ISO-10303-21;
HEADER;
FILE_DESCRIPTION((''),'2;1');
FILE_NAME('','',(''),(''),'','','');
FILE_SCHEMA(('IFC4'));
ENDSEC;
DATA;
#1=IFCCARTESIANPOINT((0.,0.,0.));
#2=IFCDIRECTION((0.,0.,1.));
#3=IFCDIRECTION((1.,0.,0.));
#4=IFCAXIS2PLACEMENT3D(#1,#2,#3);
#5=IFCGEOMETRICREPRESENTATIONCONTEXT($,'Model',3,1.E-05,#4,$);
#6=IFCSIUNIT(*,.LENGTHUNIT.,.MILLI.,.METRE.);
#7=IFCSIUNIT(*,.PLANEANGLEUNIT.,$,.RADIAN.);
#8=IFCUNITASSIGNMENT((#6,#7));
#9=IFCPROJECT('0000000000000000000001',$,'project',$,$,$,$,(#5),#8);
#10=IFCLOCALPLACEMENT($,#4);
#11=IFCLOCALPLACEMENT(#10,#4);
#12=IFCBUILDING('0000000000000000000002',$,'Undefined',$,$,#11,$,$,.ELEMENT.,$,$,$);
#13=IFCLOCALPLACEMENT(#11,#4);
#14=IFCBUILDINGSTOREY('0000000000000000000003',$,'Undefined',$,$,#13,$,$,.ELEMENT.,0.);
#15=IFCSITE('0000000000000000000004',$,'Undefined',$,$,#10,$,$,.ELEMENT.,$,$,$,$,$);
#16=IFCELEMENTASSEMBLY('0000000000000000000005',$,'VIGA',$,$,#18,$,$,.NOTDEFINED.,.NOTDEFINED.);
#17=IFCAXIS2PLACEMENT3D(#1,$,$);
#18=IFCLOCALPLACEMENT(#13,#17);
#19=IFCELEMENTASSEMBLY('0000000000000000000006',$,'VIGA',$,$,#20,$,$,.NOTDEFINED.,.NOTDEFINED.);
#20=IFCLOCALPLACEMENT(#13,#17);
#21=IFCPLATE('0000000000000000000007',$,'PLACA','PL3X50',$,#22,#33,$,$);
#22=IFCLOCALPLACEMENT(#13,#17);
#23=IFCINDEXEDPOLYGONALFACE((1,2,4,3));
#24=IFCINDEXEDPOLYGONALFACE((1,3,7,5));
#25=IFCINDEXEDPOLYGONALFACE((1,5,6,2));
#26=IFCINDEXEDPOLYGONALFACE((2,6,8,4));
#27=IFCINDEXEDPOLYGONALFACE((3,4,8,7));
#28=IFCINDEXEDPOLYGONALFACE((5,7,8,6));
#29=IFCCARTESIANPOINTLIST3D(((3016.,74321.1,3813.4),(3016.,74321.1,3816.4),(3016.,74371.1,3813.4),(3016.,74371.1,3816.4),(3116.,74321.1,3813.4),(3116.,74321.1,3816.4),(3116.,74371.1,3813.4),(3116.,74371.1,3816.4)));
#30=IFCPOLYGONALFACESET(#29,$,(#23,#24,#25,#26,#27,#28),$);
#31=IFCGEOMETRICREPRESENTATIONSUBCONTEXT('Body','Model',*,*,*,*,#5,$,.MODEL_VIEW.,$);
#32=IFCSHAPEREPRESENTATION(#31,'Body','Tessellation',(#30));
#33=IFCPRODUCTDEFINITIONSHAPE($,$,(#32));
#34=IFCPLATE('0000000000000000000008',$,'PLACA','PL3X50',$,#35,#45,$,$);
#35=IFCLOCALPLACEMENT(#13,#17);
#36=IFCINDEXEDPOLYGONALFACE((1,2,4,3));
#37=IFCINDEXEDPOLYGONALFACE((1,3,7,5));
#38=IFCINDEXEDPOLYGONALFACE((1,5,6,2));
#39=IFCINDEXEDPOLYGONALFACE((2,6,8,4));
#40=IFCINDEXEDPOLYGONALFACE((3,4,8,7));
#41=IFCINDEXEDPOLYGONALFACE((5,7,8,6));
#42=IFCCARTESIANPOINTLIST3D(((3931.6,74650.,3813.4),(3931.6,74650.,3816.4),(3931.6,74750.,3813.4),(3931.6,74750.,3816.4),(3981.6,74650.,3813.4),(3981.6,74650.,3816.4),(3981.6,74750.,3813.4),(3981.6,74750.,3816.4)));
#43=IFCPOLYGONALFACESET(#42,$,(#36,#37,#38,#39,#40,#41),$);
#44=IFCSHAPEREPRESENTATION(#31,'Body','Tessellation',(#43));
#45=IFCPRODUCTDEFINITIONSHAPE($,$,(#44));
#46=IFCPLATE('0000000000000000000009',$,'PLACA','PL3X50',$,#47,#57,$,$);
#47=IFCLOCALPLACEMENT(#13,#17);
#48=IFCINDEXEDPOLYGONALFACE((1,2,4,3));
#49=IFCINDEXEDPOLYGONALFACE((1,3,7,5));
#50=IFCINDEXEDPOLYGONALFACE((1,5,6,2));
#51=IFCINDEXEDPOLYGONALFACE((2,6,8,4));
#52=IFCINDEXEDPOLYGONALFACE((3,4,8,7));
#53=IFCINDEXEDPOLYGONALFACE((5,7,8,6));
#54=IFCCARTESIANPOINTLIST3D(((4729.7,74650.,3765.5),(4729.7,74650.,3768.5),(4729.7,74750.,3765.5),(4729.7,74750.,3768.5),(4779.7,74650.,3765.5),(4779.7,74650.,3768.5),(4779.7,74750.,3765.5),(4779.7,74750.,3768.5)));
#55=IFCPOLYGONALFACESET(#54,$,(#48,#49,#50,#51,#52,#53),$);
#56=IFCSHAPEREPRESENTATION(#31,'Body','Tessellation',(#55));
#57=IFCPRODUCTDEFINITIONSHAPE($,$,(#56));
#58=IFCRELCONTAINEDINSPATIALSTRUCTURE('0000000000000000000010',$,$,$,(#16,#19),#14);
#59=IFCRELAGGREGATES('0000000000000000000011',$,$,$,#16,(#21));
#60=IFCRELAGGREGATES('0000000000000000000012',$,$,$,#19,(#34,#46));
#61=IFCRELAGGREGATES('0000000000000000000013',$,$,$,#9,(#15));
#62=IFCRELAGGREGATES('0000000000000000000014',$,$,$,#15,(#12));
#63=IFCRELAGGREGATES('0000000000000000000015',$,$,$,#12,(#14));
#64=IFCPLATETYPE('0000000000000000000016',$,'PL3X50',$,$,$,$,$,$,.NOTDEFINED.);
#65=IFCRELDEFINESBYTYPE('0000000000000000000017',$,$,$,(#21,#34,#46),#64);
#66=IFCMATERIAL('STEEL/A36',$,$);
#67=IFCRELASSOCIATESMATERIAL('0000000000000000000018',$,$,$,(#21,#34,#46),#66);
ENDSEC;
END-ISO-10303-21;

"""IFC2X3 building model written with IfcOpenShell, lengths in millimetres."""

from ifc_helpers import new_model, si_unit, frame, origin_with_axes, place, context, subcontext, project, spatial, polyline, outline, extrude, material, type_object, element, aggregate, save


model = new_model("IFC2X3")

# Units and contexts
model_context = context("Model", 3, precision=1e-05, world=origin_with_axes())
body_context = subcontext(model_context, "Body", "Model", "MODEL_VIEW")
ifc_project = project(units=[si_unit("LENGTHUNIT", "METRE", prefix="MILLI"), si_unit("PLANEANGLEUNIT", "RADIAN")], contexts=[model_context])

# Site, building, storey
site_placement = place(None, origin_with_axes())
site = spatial("IfcSite", under=ifc_project, at=site_placement, Name="Undefined", CompositionType="ELEMENT")
building_placement = place(site_placement, origin_with_axes())
building = spatial("IfcBuilding", under=site, at=building_placement, Name="Undefined", CompositionType="ELEMENT")
storey_placement = place(building_placement, origin_with_axes())
storey = spatial("IfcBuildingStorey", under=building, at=storey_placement, Name="Undefined", CompositionType="ELEMENT", Elevation=0.0)

# Element assembly
assembly_1_placement = place(storey_placement, origin_with_axes())
assembly_1 = element("IfcElementAssembly", 1, at=assembly_1_placement, inside=storey, Name="VIGA", AssemblyPlace="NOTDEFINED", PredefinedType="NOTDEFINED")
ifc_material_1 = material(Name="STEEL/A36")

# Element assembly
assembly_2_placement = place(storey_placement, origin_with_axes())
assembly_2 = element("IfcElementAssembly", 2, at=assembly_2_placement, inside=storey, Name="VIGA", AssemblyPlace="NOTDEFINED", PredefinedType="NOTDEFINED")

# Plates
plate_type_1 = type_object("IfcPlateType", Name="PL3X50", PredefinedType="NOTDEFINED")
plate_1_placement = place(assembly_1_placement, frame((3016.0, 74321.1, 3814.9), z_axis=(0.0, 0.0, -1.0), x_axis=(0.0, 1.0, 0.0)))
plate_1 = element("IfcPlate", 3, at=plate_1_placement, type_object=plate_type_1, material=ifc_material_1, Name="PLACA", Description="PL3X50", context=body_context, shape_type="SweptSolid", body=[
    extrude(outline(polyline([(0.0, 0.0), (50.0, 0.0), (50.0, 100.0), (0.0, 100.0), (0.0, 0.0)])), frame((0.0, 0.0, -1.5), z_axis=(0.0, 0.0, 1.0), x_axis=(1.0, 0.0, 0.0)), (0.0, 0.0, 1.0), 3.0),
])
aggregate(assembly_1, [plate_1])
plate_2_placement = place(assembly_2_placement, frame((3981.6, 74650.0, 3814.9), z_axis=(0.0, 0.0, -1.0), x_axis=(-1.0, 0.0, 0.0)))
plate_2 = element("IfcPlate", 4, at=plate_2_placement, type_object=plate_type_1, material=ifc_material_1, Name="PLACA", Description="PL3X50", context=body_context, shape_type="SweptSolid", body=[
    extrude(outline(polyline([(0.0, 0.0), (50.0, 0.0), (50.0, 100.0), (0.0, 100.0), (0.0, 0.0)])), frame((0.0, 0.0, -1.5), z_axis=(0.0, 0.0, 1.0), x_axis=(1.0, 0.0, 0.0)), (0.0, 0.0, 1.0), 3.0),
])
plate_3_placement = place(assembly_2_placement, frame((4779.7, 74650.0, 3767.0), z_axis=(0.0, 0.0, -1.0), x_axis=(-1.0, 0.0, 0.0)))
plate_3 = element("IfcPlate", 5, at=plate_3_placement, type_object=plate_type_1, material=ifc_material_1, Name="PLACA", Description="PL3X50", context=body_context, shape_type="SweptSolid", body=[
    extrude(outline(polyline([(0.0, 0.0), (50.0, 0.0), (50.0, 100.0), (0.0, 100.0), (0.0, 0.0)])), frame((0.0, 0.0, -1.5), z_axis=(0.0, 0.0, 1.0), x_axis=(1.0, 0.0, 0.0)), (0.0, 0.0, 1.0), 3.0),
])
aggregate(assembly_2, [plate_2, plate_3])

save(model, "model.ifc")
